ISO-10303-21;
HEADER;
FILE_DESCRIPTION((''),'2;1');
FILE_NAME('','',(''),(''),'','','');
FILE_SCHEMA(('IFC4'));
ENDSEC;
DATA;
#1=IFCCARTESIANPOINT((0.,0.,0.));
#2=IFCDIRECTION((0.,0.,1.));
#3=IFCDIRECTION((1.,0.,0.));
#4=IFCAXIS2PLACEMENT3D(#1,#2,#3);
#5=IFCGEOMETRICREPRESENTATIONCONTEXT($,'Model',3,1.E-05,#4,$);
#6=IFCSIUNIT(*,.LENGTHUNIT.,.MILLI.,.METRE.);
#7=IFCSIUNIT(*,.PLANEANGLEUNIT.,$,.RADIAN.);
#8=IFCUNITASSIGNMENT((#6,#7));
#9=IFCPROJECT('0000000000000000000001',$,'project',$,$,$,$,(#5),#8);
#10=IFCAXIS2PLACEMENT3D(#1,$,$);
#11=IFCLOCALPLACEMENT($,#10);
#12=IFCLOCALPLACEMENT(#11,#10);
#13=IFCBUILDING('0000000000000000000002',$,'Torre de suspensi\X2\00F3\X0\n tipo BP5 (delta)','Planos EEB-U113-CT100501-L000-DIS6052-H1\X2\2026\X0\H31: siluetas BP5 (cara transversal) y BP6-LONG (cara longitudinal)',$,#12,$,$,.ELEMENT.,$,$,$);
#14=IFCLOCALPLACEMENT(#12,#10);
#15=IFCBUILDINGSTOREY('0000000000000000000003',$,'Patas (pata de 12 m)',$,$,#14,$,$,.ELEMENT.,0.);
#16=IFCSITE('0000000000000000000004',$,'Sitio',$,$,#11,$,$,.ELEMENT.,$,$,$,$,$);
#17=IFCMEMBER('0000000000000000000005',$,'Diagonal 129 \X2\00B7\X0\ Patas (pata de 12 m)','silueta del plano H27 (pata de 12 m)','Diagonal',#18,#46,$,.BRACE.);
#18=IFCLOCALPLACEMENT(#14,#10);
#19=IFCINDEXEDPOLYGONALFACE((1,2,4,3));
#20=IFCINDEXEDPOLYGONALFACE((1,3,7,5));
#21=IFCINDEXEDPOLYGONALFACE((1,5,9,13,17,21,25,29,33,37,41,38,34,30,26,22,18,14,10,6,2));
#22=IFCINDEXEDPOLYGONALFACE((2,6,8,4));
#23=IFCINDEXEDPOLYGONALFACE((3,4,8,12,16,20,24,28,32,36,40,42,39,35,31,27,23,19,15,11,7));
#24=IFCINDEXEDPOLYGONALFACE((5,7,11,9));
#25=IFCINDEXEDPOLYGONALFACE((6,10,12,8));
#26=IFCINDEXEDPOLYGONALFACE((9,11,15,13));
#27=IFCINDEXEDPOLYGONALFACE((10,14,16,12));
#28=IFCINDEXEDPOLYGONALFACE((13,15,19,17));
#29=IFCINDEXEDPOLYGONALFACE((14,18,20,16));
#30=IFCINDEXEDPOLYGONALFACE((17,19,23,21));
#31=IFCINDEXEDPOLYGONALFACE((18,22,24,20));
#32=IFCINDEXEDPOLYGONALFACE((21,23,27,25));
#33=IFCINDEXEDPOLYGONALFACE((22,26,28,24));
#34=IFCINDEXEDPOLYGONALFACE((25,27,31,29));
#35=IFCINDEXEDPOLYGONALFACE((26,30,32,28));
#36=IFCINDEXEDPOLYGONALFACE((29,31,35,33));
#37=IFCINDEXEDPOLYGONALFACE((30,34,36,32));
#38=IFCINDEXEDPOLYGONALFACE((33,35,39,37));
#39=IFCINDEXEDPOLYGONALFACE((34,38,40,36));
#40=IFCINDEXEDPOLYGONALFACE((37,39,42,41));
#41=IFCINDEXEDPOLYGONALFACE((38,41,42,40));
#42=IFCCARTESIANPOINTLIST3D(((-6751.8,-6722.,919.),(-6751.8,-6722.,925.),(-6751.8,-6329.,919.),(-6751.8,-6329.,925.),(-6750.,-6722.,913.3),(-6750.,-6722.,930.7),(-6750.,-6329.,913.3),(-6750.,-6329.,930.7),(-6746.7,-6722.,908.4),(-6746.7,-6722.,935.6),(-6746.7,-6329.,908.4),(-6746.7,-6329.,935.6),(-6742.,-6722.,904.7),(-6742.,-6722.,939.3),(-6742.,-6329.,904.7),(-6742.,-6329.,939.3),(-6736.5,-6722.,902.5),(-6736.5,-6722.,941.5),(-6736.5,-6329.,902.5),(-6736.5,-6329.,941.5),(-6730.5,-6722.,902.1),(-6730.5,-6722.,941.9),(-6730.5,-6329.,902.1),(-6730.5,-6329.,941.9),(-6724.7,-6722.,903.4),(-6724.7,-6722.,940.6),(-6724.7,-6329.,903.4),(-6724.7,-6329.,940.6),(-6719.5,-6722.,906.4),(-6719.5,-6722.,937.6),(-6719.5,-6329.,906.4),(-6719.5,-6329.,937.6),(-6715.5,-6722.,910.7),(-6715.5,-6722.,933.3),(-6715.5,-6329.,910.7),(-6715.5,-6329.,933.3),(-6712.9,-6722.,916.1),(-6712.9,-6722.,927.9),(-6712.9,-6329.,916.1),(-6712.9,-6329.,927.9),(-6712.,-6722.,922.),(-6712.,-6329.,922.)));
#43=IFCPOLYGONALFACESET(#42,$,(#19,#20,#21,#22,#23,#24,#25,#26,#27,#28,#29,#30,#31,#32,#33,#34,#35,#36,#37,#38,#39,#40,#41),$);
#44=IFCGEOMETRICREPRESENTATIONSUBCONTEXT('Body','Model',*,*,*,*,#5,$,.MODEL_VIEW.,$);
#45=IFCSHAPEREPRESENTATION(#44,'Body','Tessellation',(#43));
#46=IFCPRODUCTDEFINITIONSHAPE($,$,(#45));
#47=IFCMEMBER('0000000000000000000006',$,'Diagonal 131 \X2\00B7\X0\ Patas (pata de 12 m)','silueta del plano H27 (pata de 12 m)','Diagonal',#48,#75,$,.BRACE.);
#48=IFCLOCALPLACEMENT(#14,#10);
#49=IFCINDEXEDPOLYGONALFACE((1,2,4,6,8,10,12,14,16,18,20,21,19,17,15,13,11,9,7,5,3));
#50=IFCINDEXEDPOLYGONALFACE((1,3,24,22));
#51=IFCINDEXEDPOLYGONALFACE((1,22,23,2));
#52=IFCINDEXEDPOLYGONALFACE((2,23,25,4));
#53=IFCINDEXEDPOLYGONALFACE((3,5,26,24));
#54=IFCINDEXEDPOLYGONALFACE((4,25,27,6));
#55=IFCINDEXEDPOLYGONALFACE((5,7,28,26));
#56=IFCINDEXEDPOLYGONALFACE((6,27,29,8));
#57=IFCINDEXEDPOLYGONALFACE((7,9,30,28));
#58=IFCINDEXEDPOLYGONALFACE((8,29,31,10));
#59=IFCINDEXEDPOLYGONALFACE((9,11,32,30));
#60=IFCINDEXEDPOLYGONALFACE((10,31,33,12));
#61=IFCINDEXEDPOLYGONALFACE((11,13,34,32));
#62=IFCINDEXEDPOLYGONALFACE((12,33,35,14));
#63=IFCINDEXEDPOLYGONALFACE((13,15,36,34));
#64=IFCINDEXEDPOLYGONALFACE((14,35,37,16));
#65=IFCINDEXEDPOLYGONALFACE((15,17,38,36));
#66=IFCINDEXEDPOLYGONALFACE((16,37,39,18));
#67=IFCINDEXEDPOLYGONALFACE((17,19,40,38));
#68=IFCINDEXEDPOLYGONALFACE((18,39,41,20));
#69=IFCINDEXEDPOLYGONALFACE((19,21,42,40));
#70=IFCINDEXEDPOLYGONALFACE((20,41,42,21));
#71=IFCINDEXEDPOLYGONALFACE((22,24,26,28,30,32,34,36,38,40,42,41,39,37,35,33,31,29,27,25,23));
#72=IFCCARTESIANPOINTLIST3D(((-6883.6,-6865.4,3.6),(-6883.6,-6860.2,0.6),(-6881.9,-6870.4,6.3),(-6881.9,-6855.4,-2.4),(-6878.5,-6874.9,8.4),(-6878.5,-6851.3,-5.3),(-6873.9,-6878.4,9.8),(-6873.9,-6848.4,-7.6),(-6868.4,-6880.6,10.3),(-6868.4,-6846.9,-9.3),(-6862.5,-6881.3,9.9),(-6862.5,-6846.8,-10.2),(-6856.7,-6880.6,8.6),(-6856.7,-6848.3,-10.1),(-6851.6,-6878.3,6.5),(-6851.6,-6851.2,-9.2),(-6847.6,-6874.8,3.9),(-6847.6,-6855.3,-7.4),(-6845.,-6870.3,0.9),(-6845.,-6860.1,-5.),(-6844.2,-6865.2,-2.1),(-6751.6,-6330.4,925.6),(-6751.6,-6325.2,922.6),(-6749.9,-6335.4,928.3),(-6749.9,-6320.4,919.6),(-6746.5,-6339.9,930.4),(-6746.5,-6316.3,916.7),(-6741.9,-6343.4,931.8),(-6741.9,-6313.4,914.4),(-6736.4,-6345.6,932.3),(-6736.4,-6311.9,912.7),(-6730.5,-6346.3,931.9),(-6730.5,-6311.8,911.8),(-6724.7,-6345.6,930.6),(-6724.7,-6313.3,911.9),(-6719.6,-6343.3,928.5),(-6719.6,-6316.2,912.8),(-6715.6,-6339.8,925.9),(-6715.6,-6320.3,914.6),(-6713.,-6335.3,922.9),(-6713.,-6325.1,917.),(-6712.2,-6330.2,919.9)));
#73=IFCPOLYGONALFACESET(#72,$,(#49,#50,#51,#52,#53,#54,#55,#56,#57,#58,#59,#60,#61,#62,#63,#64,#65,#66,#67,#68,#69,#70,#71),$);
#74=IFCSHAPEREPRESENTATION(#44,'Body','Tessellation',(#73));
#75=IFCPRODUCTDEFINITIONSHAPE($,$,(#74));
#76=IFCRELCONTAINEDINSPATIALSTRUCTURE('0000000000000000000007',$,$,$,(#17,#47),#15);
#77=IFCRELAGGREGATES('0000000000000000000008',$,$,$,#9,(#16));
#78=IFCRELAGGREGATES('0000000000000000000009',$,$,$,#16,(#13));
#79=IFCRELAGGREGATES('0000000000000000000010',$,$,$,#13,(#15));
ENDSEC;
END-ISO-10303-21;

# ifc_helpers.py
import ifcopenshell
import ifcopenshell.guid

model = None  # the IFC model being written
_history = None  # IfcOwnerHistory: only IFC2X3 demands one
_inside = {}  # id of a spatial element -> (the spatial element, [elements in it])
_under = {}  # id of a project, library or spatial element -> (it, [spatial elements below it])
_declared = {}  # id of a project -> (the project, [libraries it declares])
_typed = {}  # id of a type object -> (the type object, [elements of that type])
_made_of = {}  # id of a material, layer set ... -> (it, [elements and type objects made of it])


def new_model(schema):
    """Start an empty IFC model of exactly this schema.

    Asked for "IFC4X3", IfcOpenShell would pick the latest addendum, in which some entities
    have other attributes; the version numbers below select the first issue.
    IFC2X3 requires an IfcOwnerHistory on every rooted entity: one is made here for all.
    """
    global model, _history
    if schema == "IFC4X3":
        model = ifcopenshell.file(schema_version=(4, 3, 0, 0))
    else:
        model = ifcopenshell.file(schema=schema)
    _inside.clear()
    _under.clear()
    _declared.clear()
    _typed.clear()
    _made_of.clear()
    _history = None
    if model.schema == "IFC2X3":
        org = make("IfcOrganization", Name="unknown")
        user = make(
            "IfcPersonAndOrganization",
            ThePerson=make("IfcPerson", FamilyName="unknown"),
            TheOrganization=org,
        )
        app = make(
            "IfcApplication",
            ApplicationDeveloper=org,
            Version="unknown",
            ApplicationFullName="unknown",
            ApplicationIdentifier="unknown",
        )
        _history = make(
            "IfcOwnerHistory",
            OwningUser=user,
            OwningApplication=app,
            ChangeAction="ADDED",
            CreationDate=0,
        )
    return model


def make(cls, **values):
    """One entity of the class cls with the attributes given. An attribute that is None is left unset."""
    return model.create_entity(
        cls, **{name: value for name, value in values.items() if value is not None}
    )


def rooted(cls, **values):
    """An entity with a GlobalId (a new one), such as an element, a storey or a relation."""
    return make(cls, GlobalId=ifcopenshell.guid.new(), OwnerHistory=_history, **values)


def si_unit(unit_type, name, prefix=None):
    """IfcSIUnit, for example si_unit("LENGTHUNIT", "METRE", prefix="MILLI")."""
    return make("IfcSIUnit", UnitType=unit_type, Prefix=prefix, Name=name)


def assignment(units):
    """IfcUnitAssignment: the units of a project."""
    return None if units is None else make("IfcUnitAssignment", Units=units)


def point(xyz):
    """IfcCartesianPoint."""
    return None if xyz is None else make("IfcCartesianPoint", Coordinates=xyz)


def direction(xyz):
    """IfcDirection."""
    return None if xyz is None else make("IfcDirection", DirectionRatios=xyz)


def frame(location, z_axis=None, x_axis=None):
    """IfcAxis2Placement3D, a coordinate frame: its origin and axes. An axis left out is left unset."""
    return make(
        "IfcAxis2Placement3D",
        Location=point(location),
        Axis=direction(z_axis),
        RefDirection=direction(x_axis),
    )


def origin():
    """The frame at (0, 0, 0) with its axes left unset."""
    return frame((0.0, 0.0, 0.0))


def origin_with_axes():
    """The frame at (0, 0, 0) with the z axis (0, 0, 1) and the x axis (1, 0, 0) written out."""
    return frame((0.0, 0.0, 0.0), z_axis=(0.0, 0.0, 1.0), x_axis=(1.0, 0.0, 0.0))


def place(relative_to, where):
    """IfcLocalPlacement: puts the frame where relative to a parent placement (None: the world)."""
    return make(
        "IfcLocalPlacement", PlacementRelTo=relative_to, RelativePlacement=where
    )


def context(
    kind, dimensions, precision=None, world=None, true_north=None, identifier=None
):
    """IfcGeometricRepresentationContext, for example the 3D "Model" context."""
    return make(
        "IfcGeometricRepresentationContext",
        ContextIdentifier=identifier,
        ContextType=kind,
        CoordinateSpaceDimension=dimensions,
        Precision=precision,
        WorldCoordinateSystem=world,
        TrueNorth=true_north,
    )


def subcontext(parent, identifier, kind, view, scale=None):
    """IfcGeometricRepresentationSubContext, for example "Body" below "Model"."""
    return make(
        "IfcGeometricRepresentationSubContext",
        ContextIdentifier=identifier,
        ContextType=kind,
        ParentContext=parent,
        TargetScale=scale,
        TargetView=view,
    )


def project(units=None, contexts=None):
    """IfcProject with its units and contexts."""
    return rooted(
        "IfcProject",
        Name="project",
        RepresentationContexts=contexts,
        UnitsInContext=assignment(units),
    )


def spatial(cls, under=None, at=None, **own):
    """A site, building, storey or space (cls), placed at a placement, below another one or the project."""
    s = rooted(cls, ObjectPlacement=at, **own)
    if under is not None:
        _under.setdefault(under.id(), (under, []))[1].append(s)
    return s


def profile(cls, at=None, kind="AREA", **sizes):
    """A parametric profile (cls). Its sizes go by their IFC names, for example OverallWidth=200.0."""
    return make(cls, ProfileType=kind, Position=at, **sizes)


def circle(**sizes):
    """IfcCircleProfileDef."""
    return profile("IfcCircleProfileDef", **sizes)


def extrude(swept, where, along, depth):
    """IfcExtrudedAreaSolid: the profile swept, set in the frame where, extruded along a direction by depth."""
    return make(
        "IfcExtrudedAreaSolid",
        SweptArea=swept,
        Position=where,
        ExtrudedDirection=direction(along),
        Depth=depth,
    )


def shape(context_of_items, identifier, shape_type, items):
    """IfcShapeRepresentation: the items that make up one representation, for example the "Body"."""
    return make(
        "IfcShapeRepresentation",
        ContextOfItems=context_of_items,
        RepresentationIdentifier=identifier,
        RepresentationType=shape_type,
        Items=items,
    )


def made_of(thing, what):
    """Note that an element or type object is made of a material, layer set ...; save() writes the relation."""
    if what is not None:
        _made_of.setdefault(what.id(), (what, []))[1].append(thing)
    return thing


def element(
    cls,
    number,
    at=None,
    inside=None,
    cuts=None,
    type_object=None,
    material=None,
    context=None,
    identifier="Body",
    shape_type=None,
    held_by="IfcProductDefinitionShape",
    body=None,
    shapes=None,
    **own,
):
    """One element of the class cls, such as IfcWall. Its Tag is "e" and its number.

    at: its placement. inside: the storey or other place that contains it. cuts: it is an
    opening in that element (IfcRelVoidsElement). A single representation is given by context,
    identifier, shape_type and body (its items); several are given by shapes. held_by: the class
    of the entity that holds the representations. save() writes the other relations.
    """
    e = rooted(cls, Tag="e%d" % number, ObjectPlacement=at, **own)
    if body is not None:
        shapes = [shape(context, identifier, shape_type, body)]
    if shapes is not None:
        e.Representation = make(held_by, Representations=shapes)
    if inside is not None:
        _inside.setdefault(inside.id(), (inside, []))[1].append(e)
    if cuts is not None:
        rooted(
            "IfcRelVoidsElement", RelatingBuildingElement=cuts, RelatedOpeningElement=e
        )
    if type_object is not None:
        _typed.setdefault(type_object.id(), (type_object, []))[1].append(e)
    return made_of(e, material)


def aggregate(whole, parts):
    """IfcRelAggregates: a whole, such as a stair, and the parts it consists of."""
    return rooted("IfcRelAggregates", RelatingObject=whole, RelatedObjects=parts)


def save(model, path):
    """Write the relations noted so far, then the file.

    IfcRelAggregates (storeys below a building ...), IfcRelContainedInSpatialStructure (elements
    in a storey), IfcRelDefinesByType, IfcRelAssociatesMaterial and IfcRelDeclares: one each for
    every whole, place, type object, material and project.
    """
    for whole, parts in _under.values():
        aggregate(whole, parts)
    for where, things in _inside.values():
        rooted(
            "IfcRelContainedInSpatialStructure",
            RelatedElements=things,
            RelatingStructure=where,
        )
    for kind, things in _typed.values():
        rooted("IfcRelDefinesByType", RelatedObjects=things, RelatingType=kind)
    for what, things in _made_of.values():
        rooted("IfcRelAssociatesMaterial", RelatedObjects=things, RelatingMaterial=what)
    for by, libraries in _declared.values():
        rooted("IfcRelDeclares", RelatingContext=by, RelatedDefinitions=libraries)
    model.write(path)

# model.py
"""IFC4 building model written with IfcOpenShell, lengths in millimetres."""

from ifc_helpers import new_model, si_unit, frame, origin, origin_with_axes, place, context, subcontext, project, spatial, circle, extrude, element, save


model = new_model("IFC4")

# Units and contexts
model_context = context("Model", 3, precision=1e-05, world=origin_with_axes())
body_context = subcontext(model_context, "Body", "Model", "MODEL_VIEW")
ifc_project = project(units=[si_unit("LENGTHUNIT", "METRE", prefix="MILLI"), si_unit("PLANEANGLEUNIT", "RADIAN")], contexts=[model_context])

# Site, building, storey
site_placement = place(None, origin())
site = spatial("IfcSite", under=ifc_project, at=site_placement, Name="Sitio", CompositionType="ELEMENT")
building_placement = place(site_placement, origin())
building = spatial("IfcBuilding", under=site, at=building_placement, Name="Torre de suspensión tipo BP5 (delta)", Description="Planos EEB-U113-CT100501-L000-DIS6052-H1…H31: siluetas BP5 (cara transversal) y BP6-LONG (cara longitudinal)", CompositionType="ELEMENT")
storey_placement = place(building_placement, origin())
storey = spatial("IfcBuildingStorey", under=building, at=storey_placement, Name="Patas (pata de 12 m)", CompositionType="ELEMENT", Elevation=0.0)

# Members
member_1_placement = place(storey_placement, frame((-6732.0, -6722.0, 922.0), z_axis=(0.0, 1.0, 0.0), x_axis=(1.0, 0.0, 0.0)))
element("IfcMember", 1, at=member_1_placement, inside=storey, Name="Diagonal 129 · Patas (pata de 12 m)", Description="silueta del plano H27 (pata de 12 m)", ObjectType="Diagonal", PredefinedType="BRACE", context=body_context, shape_type="SweptSolid", body=[
    extrude(circle(Radius=20.0), None, (0.0, 0.0, 1.0), 393.0),
])
member_2_placement = place(storey_placement, frame((-6864.0, -6864.0, 0.0), z_axis=(0.122891, 0.498082, 0.858377), x_axis=(0.99242, -0.061678, -0.106293)))
element("IfcMember", 2, at=member_2_placement, inside=storey, Name="Diagonal 131 · Patas (pata de 12 m)", Description="silueta del plano H27 (pata de 12 m)", ObjectType="Diagonal", PredefinedType="BRACE", context=body_context, shape_type="SweptSolid", body=[
    extrude(circle(Radius=20.0), None, (0.0, 0.0, 1.0), 1074.1),
])

save(model, "model.ifc")
